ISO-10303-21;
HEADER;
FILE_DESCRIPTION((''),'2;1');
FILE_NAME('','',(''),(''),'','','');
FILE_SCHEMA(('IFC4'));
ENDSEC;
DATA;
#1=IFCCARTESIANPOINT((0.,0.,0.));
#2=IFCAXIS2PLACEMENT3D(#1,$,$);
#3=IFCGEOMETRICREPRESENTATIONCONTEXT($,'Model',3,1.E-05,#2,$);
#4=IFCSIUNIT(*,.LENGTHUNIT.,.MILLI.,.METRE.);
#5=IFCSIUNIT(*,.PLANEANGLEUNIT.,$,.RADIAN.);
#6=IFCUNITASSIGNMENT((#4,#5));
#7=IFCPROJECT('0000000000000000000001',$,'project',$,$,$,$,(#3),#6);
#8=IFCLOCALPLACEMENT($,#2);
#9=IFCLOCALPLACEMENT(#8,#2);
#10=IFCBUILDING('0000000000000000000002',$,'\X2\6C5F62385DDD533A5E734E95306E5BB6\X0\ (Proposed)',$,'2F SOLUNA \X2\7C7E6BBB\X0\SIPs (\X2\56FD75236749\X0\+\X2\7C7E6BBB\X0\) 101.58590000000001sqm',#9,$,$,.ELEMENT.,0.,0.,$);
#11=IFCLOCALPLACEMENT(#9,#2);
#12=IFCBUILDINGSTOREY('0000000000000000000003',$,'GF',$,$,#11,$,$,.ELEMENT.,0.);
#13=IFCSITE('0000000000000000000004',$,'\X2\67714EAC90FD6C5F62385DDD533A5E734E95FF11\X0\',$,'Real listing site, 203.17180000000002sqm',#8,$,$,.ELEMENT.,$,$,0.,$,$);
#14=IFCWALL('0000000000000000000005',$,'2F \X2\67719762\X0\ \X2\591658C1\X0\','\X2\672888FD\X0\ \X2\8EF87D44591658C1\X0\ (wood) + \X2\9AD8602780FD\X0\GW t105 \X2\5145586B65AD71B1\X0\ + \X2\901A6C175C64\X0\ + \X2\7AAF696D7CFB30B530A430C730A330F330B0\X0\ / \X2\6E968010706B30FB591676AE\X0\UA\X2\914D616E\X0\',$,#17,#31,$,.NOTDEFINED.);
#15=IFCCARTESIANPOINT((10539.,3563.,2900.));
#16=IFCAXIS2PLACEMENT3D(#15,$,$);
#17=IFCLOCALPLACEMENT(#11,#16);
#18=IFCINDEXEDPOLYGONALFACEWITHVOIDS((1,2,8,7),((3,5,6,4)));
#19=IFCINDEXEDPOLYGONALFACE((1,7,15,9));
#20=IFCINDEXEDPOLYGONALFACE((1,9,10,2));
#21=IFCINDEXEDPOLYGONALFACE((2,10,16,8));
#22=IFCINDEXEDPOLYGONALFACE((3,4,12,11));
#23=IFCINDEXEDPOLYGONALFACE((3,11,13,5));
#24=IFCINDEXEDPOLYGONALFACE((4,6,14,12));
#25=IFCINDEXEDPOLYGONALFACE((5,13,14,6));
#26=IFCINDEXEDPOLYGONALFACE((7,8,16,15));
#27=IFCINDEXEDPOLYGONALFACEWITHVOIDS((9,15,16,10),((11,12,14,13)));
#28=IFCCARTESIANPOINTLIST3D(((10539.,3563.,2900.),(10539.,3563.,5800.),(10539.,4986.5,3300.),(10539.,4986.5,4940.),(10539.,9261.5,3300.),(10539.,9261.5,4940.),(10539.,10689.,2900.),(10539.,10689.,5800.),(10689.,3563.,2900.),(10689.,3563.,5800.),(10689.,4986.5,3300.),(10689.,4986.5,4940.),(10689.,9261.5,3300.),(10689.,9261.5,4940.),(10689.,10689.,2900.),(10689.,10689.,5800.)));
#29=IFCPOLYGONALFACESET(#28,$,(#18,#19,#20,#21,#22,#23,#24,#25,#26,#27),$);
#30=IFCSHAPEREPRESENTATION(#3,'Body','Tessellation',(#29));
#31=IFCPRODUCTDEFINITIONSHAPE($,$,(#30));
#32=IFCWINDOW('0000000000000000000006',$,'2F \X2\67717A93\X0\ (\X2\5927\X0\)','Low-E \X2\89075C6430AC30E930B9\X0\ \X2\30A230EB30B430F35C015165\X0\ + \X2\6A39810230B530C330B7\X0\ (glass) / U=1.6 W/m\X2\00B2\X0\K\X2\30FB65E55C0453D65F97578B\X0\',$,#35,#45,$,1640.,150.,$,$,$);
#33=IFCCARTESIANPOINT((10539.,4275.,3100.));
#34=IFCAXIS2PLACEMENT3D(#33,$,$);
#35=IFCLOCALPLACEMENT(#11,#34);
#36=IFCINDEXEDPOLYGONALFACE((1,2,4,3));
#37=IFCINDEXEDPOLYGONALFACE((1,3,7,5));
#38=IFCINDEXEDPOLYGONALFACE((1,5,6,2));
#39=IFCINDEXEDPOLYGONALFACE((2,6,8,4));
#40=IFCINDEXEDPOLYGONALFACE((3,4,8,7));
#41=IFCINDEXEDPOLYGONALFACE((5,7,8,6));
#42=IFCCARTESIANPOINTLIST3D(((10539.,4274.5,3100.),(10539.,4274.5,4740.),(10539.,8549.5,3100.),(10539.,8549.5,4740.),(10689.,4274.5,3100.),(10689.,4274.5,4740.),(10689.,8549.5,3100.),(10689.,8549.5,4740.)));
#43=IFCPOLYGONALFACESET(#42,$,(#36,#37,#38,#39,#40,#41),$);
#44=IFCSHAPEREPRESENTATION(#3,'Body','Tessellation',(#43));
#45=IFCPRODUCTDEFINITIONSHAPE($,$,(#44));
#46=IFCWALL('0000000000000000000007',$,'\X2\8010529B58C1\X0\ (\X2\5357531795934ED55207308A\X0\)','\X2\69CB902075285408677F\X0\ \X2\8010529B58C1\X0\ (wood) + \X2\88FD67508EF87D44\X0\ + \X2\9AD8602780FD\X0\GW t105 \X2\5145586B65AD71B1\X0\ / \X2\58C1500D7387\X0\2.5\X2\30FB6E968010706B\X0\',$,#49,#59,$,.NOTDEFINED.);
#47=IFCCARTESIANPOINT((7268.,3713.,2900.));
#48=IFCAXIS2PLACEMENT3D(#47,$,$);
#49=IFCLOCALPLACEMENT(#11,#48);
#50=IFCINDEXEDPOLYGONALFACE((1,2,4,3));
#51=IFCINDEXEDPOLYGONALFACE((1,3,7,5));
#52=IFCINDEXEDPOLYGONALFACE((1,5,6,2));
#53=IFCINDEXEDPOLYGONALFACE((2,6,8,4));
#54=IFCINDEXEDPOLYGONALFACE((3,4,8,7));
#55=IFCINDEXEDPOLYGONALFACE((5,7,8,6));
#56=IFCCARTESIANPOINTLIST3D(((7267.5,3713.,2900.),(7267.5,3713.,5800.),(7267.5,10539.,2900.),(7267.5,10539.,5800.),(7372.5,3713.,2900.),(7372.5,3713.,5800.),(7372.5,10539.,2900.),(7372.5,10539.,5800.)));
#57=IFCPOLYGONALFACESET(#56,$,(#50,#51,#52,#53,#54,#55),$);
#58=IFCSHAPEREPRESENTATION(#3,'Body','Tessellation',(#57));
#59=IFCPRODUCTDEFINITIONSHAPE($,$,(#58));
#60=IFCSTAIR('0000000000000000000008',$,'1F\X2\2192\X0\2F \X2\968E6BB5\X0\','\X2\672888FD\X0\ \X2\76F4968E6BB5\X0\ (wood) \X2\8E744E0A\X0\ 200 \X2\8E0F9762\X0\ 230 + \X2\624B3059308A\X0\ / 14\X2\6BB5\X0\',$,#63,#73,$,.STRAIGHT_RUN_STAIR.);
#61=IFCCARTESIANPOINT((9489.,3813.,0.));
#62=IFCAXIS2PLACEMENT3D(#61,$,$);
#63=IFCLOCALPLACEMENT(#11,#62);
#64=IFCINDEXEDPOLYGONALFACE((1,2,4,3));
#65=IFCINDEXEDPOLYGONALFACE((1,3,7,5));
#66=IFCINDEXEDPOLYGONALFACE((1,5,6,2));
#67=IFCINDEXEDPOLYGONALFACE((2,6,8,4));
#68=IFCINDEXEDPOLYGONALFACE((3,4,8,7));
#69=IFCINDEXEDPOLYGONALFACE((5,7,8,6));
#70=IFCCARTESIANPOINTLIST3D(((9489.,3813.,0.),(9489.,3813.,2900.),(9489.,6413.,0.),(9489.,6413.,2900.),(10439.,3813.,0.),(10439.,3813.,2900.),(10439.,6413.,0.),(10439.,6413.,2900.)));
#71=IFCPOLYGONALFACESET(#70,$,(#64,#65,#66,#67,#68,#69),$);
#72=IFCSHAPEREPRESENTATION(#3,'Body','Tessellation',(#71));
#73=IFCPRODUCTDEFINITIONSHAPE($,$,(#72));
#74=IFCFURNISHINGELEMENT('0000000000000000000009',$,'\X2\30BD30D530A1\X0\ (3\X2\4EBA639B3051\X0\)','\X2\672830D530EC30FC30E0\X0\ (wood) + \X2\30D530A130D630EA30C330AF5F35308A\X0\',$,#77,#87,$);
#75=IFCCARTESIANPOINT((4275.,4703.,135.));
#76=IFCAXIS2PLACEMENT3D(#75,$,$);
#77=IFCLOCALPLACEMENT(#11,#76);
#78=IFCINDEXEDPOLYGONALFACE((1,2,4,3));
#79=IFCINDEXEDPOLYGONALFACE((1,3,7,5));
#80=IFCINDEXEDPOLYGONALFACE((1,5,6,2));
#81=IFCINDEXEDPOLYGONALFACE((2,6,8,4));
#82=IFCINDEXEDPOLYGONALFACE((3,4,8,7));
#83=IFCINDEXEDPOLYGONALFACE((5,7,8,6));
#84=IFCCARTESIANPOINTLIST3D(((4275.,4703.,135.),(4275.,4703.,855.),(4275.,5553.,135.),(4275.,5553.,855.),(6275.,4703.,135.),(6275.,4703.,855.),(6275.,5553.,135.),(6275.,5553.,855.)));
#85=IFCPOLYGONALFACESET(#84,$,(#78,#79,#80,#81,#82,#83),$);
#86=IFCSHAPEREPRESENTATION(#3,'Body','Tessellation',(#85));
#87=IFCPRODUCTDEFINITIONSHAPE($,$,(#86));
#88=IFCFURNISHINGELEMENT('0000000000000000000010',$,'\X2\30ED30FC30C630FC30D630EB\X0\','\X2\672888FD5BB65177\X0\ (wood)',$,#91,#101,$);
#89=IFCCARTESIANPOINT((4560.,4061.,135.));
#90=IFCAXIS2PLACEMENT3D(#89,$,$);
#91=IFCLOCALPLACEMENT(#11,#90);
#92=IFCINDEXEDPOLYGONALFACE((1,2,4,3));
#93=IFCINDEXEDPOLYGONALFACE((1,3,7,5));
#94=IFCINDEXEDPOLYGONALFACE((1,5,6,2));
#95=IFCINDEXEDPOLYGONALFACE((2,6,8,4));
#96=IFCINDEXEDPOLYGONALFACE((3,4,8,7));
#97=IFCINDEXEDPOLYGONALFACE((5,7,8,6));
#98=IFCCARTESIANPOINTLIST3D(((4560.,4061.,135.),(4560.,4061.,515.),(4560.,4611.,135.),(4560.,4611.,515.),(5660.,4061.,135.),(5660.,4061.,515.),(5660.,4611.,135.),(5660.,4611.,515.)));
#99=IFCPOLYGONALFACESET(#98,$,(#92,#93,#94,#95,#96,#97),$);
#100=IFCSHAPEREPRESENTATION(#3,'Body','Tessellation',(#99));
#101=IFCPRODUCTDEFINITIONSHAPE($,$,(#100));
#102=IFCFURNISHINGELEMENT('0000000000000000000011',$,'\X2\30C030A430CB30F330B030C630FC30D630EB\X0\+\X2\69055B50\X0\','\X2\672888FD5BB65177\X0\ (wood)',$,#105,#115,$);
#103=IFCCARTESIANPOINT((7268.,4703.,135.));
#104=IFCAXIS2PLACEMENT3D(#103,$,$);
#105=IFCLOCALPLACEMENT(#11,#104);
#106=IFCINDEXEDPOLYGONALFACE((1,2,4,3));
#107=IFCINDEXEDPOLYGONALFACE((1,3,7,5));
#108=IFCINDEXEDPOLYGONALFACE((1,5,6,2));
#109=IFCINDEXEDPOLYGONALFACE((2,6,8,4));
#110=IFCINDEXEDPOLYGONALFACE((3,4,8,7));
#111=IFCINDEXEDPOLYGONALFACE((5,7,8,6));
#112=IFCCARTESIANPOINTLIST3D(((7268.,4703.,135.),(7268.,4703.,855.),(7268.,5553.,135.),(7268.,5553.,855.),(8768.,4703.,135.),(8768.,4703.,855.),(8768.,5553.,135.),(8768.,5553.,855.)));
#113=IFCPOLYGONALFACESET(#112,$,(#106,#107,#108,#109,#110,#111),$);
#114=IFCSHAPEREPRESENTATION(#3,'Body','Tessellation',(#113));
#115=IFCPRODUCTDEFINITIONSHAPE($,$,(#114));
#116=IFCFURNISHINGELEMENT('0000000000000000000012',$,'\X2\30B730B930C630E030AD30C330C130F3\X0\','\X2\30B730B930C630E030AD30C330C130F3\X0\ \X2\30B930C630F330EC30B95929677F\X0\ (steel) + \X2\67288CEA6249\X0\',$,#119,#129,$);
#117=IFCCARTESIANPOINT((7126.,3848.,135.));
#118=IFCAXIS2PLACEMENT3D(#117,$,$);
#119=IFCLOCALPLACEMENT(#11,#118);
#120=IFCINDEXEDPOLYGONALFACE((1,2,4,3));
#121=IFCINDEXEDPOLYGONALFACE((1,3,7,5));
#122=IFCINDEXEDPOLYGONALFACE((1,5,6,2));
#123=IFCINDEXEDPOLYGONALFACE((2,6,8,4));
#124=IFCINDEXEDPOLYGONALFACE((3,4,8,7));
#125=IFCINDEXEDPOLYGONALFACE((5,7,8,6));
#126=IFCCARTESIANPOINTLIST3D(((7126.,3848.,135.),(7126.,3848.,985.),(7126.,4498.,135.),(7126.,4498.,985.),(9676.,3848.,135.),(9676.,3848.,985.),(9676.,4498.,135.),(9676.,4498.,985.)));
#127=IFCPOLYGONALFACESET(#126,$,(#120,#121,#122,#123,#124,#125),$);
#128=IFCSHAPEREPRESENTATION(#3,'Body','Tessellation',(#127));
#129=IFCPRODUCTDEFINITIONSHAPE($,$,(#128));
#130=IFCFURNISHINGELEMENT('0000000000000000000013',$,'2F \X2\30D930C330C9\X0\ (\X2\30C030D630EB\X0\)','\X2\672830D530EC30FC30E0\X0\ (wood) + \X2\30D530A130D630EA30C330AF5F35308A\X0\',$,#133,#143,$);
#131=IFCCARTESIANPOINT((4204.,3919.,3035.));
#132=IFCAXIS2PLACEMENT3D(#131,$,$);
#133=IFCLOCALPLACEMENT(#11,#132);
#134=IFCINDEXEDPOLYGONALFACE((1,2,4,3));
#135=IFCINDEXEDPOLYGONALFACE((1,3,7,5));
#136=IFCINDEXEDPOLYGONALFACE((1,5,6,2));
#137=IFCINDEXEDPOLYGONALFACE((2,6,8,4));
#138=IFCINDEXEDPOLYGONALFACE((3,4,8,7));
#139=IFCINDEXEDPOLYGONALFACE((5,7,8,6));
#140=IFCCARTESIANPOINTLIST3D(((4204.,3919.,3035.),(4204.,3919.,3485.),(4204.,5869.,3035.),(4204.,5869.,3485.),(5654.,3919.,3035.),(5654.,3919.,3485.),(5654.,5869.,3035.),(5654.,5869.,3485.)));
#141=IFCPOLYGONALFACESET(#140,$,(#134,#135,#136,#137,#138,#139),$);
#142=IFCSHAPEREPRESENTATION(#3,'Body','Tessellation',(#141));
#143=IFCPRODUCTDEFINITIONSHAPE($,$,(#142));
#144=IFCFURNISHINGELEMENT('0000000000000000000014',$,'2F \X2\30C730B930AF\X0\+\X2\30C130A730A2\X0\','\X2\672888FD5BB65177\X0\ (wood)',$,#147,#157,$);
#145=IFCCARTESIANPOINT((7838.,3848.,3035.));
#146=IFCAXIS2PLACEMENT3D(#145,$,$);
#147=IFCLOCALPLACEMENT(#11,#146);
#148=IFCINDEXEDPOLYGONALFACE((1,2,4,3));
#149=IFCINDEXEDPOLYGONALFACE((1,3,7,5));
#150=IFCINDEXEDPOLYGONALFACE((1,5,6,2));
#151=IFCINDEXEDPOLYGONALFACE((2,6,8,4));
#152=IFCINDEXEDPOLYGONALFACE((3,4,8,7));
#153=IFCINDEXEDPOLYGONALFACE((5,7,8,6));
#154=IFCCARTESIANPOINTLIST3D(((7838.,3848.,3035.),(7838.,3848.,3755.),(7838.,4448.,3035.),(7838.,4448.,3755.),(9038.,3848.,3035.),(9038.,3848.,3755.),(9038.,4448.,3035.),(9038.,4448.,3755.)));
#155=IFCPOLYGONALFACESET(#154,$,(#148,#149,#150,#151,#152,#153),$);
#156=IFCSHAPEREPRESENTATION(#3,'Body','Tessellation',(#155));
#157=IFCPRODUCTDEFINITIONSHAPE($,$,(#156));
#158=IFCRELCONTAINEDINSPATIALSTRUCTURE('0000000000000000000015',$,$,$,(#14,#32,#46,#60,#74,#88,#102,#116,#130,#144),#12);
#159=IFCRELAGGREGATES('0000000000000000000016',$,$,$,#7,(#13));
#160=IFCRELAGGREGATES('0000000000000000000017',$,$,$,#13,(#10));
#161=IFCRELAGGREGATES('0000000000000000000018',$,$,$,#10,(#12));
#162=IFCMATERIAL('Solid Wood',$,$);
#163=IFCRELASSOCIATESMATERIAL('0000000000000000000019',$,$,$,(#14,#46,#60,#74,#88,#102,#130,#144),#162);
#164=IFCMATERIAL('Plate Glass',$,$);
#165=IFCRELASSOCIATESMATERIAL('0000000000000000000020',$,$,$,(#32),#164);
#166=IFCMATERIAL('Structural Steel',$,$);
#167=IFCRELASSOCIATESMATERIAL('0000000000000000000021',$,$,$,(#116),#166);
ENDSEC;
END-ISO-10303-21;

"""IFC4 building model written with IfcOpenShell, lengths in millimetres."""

from ifc_helpers import new_model, si_unit, frame, frame_2d, origin, place, context, project, spatial, rectangle, extrude, material, element, fill, save


model = new_model("IFC4")

# Units and contexts
model_context = context("Model", 3, precision=1e-05, world=origin())
ifc_project = project(units=[si_unit("LENGTHUNIT", "METRE", prefix="MILLI"), si_unit("PLANEANGLEUNIT", "RADIAN")], contexts=[model_context])

# Site, building, storey
site_placement = place(None, origin())
site = spatial("IfcSite", under=ifc_project, at=site_placement, Name="東京都江戸川区平井１", ObjectType="Real listing site, 203.17180000000002sqm", CompositionType="ELEMENT", RefElevation=0.0)
building_placement = place(site_placement, origin())
building = spatial("IfcBuilding", under=site, at=building_placement, Name="江戸川区平井の家 (Proposed)", ObjectType="2F SOLUNA 籾殻SIPs (国産杉+籾殻) 101.58590000000001sqm", CompositionType="ELEMENT", ElevationOfRefHeight=0.0, ElevationOfTerrain=0.0)
storey_placement = place(building_placement, origin())
storey = spatial("IfcBuildingStorey", under=building, at=storey_placement, Name="GF", CompositionType="ELEMENT", Elevation=0.0)

# Shared definitions
ifc_material_1 = material(Name="Solid Wood")
ifc_material_2 = material(Name="Plate Glass")

# Wall, opening, window
wall_1_placement = place(storey_placement, frame((10539.0, 3563.0, 2900.0)))
wall_1 = element("IfcWall", 1, at=wall_1_placement, inside=storey, material=ifc_material_1, Name="2F 東面 外壁", Description="木製 軸組外壁 (wood) + 高性能GW t105 充填断熱 + 通気層 + 窯業系サイディング / 準耐火・外皮UA配慮", PredefinedType="NOTDEFINED", context=model_context, shape_type="SweptSolid", body=[
    extrude(rectangle(XDim=150.0, YDim=7126.0, at=frame_2d((75.0, 3563.0))), frame((10539.0, 3563.0, 2900.0)), (0.0, 0.0, 1.0), 2900.0),
])
opening_1_placement = place(storey_placement, frame((10539.0, 4275.0, 3100.0)))
opening_1 = element("IfcOpeningElement", 2, at=opening_1_placement, cuts=wall_1, PredefinedType="NOTDEFINED", context=model_context, shape_type="SweptSolid", body=[
    extrude(rectangle(XDim=150.0, YDim=4275.0, at=frame_2d((75.0, 2137.0))), frame((10539.0, 4275.0, 3100.0)), (0.0, 0.0, 1.0), 1640.0),
])
window_1_placement = place(storey_placement, frame((10539.0, 4275.0, 3100.0)))
window_1 = element("IfcWindow", 3, at=window_1_placement, inside=storey, material=ifc_material_2, Name="2F 東窓 (大)", Description="Low-E 複層ガラス アルゴン封入 + 樹脂サッシ (glass) / U=1.6 W/m²K・日射取得型", OverallHeight=1640.0, OverallWidth=150.0, context=model_context, shape_type="SweptSolid", body=[
    extrude(rectangle(XDim=150.0, YDim=4275.0, at=frame_2d((75.0, 2137.0))), frame((10539.0, 4275.0, 3100.0)), (0.0, 0.0, 1.0), 1640.0),
])
fill(opening_1, window_1)

# Wall
wall_2_placement = place(storey_placement, frame((7268.0, 3713.0, 2900.0)))
element("IfcWall", 4, at=wall_2_placement, inside=storey, material=ifc_material_1, Name="耐力壁 (南北間仕切り)", Description="構造用合板 耐力壁 (wood) + 製材軸組 + 高性能GW t105 充填断熱 / 壁倍率2.5・準耐火", PredefinedType="NOTDEFINED", context=model_context, shape_type="SweptSolid", body=[
    extrude(rectangle(XDim=105.0, YDim=6826.0, at=frame_2d((52.0, 3413.0))), frame((7268.0, 3713.0, 2900.0)), (0.0, 0.0, 1.0), 2900.0),
])

# Stair
stair_placement = place(storey_placement, frame((9489.0, 3813.0, 0.0)))
element("IfcStair", 5, at=stair_placement, inside=storey, material=ifc_material_1, Name="1F→2F 階段", Description="木製 直階段 (wood) 蹴上 200 踏面 230 + 手すり / 14段", PredefinedType="STRAIGHT_RUN_STAIR", context=model_context, shape_type="SweptSolid", body=[
    extrude(rectangle(XDim=950.0, YDim=2600.0, at=frame_2d((475.0, 1300.0))), frame((9489.0, 3813.0, 0.0)), (0.0, 0.0, 1.0), 2900.0),
])

# Furnishing elements
furnishing_1_placement = place(storey_placement, frame((4275.0, 4703.0, 135.0)))
element("IfcFurnishingElement", 6, at=furnishing_1_placement, inside=storey, material=ifc_material_1, Name="ソファ (3人掛け)", Description="木フレーム (wood) + ファブリック張り", context=model_context, shape_type="SweptSolid", body=[
    extrude(rectangle(XDim=2000.0, YDim=850.0, at=frame_2d((1000.0, 425.0))), frame((4275.0, 4703.0, 135.0)), (0.0, 0.0, 1.0), 720.0),
])
furnishing_2_placement = place(storey_placement, frame((4560.0, 4061.0, 135.0)))
element("IfcFurnishingElement", 7, at=furnishing_2_placement, inside=storey, material=ifc_material_1, Name="ローテーブル", Description="木製家具 (wood)", context=model_context, shape_type="SweptSolid", body=[
    extrude(rectangle(XDim=1100.0, YDim=550.0, at=frame_2d((550.0, 275.0))), frame((4560.0, 4061.0, 135.0)), (0.0, 0.0, 1.0), 380.0),
])
furnishing_3_placement = place(storey_placement, frame((7268.0, 4703.0, 135.0)))
element("IfcFurnishingElement", 8, at=furnishing_3_placement, inside=storey, material=ifc_material_1, Name="ダイニングテーブル+椅子", Description="木製家具 (wood)", context=model_context, shape_type="SweptSolid", body=[
    extrude(rectangle(XDim=1500.0, YDim=850.0, at=frame_2d((750.0, 425.0))), frame((7268.0, 4703.0, 135.0)), (0.0, 0.0, 1.0), 720.0),
])
ifc_material_3 = material(Name="Structural Steel")
furnishing_4_placement = place(storey_placement, frame((7126.0, 3848.0, 135.0)))
element("IfcFurnishingElement", 9, at=furnishing_4_placement, inside=storey, material=ifc_material_3, Name="システムキッチン", Description="システムキッチン ステンレス天板 (steel) + 木質扉", context=model_context, shape_type="SweptSolid", body=[
    extrude(rectangle(XDim=2550.0, YDim=650.0, at=frame_2d((1275.0, 325.0))), frame((7126.0, 3848.0, 135.0)), (0.0, 0.0, 1.0), 850.0),
])
furnishing_5_placement = place(storey_placement, frame((4204.0, 3919.0, 3035.0)))
element("IfcFurnishingElement", 10, at=furnishing_5_placement, inside=storey, material=ifc_material_1, Name="2F ベッド (ダブル)", Description="木フレーム (wood) + ファブリック張り", context=model_context, shape_type="SweptSolid", body=[
    extrude(rectangle(XDim=1450.0, YDim=1950.0, at=frame_2d((725.0, 975.0))), frame((4204.0, 3919.0, 3035.0)), (0.0, 0.0, 1.0), 450.0),
])
furnishing_6_placement = place(storey_placement, frame((7838.0, 3848.0, 3035.0)))
element("IfcFurnishingElement", 11, at=furnishing_6_placement, inside=storey, material=ifc_material_1, Name="2F デスク+チェア", Description="木製家具 (wood)", context=model_context, shape_type="SweptSolid", body=[
    extrude(rectangle(XDim=1200.0, YDim=600.0, at=frame_2d((600.0, 300.0))), frame((7838.0, 3848.0, 3035.0)), (0.0, 0.0, 1.0), 720.0),
])

save(model, "model.ifc")
